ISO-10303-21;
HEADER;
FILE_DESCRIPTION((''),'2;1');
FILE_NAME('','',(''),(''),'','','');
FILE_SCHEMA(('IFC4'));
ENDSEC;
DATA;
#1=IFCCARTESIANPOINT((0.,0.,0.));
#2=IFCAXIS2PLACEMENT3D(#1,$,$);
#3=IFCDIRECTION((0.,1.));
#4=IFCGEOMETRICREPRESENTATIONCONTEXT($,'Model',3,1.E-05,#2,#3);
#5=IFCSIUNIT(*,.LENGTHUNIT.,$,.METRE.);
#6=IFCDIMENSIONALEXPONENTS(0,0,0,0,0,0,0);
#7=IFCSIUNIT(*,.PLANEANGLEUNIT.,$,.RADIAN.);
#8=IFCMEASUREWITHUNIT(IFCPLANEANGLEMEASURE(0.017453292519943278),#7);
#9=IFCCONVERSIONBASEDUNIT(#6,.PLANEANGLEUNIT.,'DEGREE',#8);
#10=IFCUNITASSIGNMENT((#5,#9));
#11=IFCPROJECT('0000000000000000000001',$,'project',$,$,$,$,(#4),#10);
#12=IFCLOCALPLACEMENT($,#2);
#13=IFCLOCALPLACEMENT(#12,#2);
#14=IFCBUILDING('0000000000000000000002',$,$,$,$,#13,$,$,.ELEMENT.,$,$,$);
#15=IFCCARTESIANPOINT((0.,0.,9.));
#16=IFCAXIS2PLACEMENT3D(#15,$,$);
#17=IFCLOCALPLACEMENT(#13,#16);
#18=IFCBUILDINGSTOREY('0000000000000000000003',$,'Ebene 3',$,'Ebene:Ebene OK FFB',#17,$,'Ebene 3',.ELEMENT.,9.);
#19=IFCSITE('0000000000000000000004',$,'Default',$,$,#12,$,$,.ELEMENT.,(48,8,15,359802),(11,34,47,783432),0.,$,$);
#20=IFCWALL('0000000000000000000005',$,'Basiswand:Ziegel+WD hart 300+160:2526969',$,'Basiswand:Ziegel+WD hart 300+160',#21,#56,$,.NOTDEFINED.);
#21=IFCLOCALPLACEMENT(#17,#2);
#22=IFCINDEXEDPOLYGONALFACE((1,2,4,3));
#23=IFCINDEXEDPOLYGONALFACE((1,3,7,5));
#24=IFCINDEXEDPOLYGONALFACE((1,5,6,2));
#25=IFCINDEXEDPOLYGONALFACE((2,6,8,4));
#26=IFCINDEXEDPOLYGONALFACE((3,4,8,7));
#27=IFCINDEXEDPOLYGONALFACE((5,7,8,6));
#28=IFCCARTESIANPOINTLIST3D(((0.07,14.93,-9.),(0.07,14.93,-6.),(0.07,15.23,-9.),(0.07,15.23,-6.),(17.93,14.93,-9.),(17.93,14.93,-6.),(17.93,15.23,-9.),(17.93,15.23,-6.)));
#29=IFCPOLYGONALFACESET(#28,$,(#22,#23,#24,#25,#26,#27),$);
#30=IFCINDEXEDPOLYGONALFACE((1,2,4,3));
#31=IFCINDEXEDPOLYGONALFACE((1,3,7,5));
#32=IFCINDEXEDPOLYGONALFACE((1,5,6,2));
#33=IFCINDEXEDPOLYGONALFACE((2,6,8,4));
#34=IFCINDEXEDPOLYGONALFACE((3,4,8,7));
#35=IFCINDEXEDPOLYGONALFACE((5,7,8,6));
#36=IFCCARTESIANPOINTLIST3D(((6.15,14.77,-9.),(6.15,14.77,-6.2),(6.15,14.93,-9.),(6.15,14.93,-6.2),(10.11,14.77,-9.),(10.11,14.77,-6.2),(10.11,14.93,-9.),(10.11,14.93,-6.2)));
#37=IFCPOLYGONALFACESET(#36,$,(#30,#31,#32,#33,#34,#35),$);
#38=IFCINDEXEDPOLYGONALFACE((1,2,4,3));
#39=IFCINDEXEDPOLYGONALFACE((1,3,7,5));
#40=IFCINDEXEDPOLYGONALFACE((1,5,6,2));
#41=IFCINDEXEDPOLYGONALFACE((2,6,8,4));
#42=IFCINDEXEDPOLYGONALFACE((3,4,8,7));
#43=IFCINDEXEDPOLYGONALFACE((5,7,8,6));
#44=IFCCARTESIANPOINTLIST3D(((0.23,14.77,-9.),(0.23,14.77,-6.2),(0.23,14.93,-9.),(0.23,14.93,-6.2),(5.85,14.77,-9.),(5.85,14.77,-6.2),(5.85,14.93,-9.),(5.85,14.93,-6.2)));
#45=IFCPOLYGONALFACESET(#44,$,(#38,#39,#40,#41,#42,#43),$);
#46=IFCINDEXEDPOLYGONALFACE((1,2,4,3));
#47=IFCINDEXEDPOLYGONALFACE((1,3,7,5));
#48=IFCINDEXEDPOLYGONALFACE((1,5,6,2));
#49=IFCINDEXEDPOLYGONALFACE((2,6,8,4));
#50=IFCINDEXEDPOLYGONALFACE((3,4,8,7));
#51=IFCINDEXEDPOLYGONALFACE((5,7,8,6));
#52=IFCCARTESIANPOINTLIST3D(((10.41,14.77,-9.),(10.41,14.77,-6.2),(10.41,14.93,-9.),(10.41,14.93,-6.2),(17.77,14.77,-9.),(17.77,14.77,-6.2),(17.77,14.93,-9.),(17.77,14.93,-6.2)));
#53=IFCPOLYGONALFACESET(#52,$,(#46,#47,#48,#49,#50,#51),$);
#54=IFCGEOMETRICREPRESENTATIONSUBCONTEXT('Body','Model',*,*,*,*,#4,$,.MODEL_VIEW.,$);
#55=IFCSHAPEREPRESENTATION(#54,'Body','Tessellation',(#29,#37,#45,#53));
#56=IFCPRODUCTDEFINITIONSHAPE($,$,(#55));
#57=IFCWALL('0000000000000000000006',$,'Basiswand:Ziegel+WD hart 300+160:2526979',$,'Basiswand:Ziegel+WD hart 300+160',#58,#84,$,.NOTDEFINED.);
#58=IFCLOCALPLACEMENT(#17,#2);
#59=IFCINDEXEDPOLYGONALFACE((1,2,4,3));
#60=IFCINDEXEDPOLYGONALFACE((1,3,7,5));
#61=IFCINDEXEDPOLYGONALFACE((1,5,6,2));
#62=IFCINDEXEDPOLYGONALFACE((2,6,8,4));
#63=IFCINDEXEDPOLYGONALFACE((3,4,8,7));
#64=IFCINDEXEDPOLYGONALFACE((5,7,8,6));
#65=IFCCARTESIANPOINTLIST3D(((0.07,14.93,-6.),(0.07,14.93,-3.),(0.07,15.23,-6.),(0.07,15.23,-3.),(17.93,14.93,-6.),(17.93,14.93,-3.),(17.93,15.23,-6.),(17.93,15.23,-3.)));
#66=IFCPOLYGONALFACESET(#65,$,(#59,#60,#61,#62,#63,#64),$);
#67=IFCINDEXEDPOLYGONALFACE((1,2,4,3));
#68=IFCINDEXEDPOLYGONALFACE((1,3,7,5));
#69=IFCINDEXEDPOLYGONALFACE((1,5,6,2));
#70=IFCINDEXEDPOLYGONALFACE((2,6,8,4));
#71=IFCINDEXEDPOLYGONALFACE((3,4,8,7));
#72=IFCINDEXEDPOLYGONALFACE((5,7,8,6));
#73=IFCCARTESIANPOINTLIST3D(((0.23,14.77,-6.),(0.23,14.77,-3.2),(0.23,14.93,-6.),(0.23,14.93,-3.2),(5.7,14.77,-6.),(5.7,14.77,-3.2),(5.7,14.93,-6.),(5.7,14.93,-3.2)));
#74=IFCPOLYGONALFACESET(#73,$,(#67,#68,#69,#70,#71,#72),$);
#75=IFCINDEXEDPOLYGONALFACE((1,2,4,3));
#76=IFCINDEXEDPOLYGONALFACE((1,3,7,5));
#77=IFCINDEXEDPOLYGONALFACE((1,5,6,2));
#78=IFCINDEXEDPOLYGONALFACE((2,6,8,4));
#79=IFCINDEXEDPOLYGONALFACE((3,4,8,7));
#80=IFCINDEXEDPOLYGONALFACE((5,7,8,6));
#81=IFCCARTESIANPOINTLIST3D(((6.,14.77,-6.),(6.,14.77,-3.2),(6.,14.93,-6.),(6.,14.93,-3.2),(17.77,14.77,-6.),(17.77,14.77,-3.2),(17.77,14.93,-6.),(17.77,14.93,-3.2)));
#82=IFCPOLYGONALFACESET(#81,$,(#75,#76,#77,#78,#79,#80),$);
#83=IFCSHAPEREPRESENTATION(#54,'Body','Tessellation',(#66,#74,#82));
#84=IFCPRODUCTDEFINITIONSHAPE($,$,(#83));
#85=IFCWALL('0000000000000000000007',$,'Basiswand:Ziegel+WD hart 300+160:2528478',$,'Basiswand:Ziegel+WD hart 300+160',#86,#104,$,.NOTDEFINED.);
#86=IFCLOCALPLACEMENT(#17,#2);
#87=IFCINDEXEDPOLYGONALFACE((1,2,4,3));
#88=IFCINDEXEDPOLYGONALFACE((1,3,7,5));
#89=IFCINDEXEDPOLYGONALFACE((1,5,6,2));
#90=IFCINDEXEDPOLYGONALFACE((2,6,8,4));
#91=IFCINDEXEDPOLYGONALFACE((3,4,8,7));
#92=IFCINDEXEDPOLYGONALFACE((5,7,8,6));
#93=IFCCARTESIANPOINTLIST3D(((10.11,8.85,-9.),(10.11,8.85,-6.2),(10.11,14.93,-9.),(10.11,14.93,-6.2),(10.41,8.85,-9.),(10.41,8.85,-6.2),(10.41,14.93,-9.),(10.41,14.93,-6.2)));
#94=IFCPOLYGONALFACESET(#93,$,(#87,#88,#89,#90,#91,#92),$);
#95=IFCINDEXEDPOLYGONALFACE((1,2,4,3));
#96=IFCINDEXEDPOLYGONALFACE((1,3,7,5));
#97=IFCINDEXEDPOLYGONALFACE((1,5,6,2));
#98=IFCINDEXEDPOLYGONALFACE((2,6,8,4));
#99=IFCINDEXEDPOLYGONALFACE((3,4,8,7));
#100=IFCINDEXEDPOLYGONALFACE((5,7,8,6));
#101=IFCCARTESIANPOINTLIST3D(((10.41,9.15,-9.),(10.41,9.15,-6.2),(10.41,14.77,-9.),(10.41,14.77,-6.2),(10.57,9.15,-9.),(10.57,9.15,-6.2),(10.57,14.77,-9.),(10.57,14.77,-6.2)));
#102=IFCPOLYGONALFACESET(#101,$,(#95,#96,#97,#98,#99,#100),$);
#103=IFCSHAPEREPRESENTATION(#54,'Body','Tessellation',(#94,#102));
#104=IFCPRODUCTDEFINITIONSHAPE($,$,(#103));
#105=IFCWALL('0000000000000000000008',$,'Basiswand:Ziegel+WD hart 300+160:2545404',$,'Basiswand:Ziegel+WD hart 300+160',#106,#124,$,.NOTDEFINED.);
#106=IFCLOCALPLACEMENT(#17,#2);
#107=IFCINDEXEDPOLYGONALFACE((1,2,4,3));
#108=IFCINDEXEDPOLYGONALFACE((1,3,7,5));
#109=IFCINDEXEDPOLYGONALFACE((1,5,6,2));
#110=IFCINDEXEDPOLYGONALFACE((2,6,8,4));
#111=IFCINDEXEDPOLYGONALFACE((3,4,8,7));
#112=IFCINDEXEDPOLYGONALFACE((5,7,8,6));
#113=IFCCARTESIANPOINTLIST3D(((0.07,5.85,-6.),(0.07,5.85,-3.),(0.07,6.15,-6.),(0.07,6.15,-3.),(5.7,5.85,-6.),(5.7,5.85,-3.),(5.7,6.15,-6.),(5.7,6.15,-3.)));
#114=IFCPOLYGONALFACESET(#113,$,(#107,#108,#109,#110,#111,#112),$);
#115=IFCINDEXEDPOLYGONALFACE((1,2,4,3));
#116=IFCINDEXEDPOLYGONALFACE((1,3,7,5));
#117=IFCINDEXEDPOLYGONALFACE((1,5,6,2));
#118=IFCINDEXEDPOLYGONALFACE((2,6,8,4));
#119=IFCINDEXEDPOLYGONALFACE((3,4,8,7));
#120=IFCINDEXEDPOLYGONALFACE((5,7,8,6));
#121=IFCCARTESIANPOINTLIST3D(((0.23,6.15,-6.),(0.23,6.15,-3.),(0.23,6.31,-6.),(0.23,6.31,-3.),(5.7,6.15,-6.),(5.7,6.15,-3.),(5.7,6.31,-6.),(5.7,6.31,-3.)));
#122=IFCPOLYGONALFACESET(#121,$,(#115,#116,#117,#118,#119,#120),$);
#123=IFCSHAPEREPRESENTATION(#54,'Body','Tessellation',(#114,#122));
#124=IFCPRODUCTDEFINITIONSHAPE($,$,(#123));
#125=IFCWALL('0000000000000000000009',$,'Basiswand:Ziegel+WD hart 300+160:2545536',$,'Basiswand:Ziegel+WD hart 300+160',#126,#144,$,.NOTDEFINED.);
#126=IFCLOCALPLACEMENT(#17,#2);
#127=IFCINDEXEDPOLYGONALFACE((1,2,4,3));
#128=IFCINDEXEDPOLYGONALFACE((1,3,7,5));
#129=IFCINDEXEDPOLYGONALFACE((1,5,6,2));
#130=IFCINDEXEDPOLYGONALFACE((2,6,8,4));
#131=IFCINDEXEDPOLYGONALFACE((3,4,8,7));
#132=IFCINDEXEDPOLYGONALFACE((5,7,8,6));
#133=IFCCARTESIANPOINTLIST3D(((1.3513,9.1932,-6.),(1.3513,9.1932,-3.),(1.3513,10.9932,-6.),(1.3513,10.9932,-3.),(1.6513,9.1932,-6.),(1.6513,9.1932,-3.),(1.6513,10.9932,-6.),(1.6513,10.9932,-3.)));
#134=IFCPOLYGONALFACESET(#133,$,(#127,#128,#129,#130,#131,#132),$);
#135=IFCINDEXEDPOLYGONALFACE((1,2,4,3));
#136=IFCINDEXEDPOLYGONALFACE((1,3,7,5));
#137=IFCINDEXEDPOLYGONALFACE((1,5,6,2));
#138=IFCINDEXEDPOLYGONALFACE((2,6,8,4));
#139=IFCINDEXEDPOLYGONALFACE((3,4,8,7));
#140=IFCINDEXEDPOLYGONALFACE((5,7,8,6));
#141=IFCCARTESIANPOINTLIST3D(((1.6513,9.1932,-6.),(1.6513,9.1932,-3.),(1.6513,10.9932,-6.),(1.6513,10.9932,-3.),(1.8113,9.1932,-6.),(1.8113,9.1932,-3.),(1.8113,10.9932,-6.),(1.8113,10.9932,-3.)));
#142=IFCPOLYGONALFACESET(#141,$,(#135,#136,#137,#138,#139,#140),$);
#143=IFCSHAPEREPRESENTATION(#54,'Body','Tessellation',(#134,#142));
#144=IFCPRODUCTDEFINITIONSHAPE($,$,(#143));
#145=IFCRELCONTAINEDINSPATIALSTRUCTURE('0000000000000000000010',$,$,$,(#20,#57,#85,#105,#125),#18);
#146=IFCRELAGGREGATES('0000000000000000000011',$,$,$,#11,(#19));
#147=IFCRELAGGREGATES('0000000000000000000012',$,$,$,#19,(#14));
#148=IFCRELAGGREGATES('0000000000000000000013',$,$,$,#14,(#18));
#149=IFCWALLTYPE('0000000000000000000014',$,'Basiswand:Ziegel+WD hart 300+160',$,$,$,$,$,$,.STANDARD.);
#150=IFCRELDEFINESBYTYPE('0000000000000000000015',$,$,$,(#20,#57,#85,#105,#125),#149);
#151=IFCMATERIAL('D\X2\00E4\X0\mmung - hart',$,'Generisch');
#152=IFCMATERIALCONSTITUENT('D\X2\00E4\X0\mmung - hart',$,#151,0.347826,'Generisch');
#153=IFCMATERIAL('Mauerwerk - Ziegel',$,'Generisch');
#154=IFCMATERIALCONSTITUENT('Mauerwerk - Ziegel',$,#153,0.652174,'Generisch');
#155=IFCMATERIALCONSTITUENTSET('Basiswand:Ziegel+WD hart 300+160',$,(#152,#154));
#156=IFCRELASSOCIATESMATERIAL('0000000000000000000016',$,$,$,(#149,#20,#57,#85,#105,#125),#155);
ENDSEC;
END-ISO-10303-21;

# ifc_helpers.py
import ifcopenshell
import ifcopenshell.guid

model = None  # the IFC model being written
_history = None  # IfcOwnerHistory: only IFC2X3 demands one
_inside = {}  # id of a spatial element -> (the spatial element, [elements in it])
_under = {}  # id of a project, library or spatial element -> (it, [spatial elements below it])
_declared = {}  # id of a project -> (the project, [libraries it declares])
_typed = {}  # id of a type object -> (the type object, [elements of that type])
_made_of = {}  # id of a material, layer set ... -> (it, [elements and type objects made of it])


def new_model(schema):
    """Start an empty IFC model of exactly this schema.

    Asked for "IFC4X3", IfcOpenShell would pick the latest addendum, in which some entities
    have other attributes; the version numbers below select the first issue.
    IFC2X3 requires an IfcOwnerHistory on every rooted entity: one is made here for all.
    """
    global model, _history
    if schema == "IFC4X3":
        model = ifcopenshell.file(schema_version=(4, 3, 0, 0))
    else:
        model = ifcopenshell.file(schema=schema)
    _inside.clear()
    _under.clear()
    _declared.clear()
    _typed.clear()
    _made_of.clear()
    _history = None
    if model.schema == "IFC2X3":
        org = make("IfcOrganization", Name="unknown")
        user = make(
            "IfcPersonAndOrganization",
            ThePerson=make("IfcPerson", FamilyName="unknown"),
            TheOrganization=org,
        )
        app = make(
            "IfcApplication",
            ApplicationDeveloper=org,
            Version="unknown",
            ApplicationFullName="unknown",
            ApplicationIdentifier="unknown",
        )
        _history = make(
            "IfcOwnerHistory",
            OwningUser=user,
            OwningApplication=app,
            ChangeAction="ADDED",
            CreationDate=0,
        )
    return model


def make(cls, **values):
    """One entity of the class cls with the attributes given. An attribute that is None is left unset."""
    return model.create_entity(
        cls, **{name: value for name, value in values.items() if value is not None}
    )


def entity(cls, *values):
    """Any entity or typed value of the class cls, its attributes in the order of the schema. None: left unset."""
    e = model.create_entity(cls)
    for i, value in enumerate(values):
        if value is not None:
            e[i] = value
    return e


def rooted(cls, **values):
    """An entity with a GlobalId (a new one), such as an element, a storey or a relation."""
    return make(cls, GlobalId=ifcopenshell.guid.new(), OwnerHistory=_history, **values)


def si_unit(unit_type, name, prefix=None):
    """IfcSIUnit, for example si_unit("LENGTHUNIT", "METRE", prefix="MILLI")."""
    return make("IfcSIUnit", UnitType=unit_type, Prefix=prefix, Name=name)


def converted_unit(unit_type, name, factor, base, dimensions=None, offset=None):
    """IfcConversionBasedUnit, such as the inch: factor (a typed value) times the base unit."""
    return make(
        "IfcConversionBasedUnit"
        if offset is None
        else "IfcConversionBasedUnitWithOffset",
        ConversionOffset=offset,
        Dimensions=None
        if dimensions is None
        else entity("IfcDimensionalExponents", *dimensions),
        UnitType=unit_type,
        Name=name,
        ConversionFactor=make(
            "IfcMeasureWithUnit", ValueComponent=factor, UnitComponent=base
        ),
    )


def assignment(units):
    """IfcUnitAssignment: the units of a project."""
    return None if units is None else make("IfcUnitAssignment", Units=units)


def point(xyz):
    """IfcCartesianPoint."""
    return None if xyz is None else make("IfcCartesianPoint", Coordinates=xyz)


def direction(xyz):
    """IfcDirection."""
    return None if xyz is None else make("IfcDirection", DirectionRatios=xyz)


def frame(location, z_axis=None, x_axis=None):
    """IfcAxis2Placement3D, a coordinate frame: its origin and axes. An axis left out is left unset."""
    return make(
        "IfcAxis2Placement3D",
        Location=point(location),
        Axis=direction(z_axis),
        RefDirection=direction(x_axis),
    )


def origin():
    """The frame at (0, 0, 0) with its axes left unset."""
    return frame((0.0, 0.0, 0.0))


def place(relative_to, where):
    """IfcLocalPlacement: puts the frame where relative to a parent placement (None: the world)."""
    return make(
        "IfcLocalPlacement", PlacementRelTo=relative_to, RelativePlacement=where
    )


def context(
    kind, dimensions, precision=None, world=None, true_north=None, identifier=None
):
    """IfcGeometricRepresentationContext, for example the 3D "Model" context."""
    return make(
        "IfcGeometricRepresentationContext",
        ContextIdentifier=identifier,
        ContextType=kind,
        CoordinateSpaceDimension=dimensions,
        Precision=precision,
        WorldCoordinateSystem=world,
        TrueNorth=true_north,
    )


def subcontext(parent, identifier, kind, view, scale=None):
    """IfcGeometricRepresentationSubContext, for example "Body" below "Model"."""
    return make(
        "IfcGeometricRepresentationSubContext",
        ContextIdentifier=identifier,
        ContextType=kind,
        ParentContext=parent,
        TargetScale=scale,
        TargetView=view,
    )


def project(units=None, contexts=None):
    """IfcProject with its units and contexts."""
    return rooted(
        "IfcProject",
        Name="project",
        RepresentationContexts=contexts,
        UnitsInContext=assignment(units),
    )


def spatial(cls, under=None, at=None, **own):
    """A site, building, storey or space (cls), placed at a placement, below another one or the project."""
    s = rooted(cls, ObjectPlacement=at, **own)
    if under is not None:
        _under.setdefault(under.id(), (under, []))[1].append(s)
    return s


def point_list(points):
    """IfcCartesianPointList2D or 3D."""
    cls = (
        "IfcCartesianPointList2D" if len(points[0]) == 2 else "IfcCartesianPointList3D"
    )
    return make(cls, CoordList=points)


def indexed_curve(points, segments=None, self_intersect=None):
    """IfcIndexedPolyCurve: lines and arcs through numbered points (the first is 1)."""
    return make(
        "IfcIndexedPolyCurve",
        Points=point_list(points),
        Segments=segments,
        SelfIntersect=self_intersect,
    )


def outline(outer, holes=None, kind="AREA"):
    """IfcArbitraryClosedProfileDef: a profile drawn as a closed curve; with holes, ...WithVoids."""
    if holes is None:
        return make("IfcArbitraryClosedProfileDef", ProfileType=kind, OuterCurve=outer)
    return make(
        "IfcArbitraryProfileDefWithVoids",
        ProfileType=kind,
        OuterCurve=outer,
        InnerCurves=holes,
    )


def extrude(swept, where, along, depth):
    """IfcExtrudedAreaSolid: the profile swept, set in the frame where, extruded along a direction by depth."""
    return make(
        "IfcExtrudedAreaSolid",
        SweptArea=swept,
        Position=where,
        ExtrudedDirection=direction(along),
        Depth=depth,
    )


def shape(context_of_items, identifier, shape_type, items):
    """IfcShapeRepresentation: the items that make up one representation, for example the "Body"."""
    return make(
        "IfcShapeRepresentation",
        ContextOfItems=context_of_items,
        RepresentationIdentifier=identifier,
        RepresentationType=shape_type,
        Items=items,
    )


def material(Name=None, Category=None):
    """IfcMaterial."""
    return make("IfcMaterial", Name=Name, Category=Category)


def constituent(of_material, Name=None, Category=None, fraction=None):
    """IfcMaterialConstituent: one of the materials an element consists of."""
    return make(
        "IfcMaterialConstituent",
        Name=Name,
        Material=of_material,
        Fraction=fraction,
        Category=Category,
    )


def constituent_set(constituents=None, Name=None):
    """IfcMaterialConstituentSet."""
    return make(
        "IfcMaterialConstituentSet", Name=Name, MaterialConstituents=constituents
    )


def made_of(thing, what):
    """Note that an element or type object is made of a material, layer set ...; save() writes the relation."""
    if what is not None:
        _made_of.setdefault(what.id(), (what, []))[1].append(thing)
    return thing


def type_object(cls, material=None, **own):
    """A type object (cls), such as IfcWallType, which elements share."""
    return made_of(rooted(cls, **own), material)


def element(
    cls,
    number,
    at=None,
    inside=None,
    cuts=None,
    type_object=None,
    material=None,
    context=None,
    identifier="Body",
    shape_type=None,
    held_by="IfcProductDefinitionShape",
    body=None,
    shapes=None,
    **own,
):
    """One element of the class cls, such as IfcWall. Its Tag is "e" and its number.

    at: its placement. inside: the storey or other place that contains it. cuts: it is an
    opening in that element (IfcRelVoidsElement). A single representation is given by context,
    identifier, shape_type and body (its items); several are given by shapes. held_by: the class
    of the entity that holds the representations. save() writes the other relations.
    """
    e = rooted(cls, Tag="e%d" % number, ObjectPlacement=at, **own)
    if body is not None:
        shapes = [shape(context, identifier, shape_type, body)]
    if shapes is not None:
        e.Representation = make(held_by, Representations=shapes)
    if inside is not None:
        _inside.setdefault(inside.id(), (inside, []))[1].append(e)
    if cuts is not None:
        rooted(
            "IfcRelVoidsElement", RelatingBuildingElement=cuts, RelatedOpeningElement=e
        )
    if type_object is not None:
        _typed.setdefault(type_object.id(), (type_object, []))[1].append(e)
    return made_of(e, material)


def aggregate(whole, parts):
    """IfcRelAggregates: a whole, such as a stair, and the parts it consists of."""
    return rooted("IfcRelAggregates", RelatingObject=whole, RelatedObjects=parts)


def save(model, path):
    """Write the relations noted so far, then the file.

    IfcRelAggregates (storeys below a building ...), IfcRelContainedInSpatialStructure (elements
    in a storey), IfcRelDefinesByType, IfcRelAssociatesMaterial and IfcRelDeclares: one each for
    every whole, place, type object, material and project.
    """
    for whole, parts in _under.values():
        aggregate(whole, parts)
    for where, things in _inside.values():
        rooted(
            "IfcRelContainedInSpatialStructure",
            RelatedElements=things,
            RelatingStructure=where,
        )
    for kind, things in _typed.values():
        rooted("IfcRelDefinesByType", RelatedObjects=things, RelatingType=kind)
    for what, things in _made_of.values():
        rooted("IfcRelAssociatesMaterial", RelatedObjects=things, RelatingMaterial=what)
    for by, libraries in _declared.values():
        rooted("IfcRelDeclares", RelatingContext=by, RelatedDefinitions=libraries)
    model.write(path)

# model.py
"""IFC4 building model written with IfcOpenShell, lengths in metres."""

from ifc_helpers import new_model, entity, si_unit, converted_unit, direction, frame, origin, place, context, subcontext, project, spatial, indexed_curve, outline, extrude, material, constituent, constituent_set, type_object, element, save


model = new_model("IFC4")

# Units and contexts
model_context = context("Model", 3, precision=1e-05, world=origin(), true_north=direction((0.0, 1.0)))
body_context = subcontext(model_context, "Body", "Model", "MODEL_VIEW")
ifc_project = project(units=[si_unit("LENGTHUNIT", "METRE"), converted_unit("PLANEANGLEUNIT", "DEGREE", entity("IfcPlaneAngleMeasure", 0.017453292519943278), si_unit("PLANEANGLEUNIT", "RADIAN"), dimensions=[0, 0, 0, 0, 0, 0, 0])], contexts=[model_context])

# Site, building, storey
site_placement = place(None, origin())
site = spatial("IfcSite", under=ifc_project, at=site_placement, Name="Default", CompositionType="ELEMENT", RefLatitude=(48, 8, 15, 359802), RefLongitude=(11, 34, 47, 783432), RefElevation=0.0)
building_placement = place(site_placement, origin())
building = spatial("IfcBuilding", under=site, at=building_placement, CompositionType="ELEMENT")
storey_placement = place(building_placement, frame((0.0, 0.0, 9.0)))
storey = spatial("IfcBuildingStorey", under=building, at=storey_placement, Name="Ebene 3", ObjectType="Ebene:Ebene OK FFB", LongName="Ebene 3", CompositionType="ELEMENT", Elevation=9.0)

# Walls
ifc_material_1 = material(Name="Dämmung - hart", Category="Generisch")
ifc_constituent_1 = constituent(ifc_material_1, Name="Dämmung - hart", Category="Generisch", fraction=0.347826)
ifc_material_2 = material(Name="Mauerwerk - Ziegel", Category="Generisch")
ifc_constituent_2 = constituent(ifc_material_2, Name="Mauerwerk - Ziegel", Category="Generisch", fraction=0.652174)
ifc_constituent_set_1 = constituent_set(constituents=[ifc_constituent_1, ifc_constituent_2], Name="Basiswand:Ziegel+WD hart 300+160")
wall_type = type_object("IfcWallType", Name="Basiswand:Ziegel+WD hart 300+160", PredefinedType="STANDARD", material=ifc_constituent_set_1)
wall_1_placement = place(storey_placement, frame((17.77, 15.0, -9.0), z_axis=(0.0, 0.0, 1.0), x_axis=(-1.0, 0.0, 0.0)))
element("IfcWall", 1, at=wall_1_placement, inside=storey, type_object=wall_type, material=ifc_constituent_set_1, Name="Basiswand:Ziegel+WD hart 300+160:2526969", ObjectType="Basiswand:Ziegel+WD hart 300+160", PredefinedType="NOTDEFINED", context=body_context, shape_type="SweptSolid", body=[
    extrude(outline(indexed_curve([(-0.15, -8.93), (0.15, -8.93), (0.15, 8.93), (-0.15, 8.93), (-0.15, -8.93)], self_intersect=False)), frame((8.77, -0.08, 0.0), z_axis=(0.0, 0.0, 1.0), x_axis=(0.0, 1.0, 0.0)), (0.0, 0.0, 1.0), 3.0),
    extrude(outline(indexed_curve([(-1.98, -0.08), (1.98, -0.08), (1.98, 0.08), (-1.98, 0.08), (-1.98, -0.08)], self_intersect=False)), frame((9.64, 0.15, 0.0)), (0.0, 0.0, 1.0), 2.8),
    extrude(outline(indexed_curve([(-2.81, -0.08), (2.81, -0.08), (2.81, 0.08), (-2.81, 0.08), (-2.81, -0.08)], self_intersect=False)), frame((14.73, 0.15, 0.0), z_axis=(0.0, 0.0, 1.0), x_axis=(-1.0, 0.0, 0.0)), (0.0, 0.0, 1.0), 2.8),
    extrude(outline(indexed_curve([(-3.68, -0.08), (3.68, -0.08), (3.68, 0.08), (-3.68, 0.08), (-3.68, -0.08)], self_intersect=False)), frame((3.68, 0.15, 0.0)), (0.0, 0.0, 1.0), 2.8),
])
wall_2_placement = place(storey_placement, frame((17.77, 15.0, -6.0), z_axis=(0.0, 0.0, 1.0), x_axis=(-1.0, 0.0, 0.0)))
element("IfcWall", 2, at=wall_2_placement, inside=storey, type_object=wall_type, material=ifc_constituent_set_1, Name="Basiswand:Ziegel+WD hart 300+160:2526979", ObjectType="Basiswand:Ziegel+WD hart 300+160", PredefinedType="NOTDEFINED", context=body_context, shape_type="SweptSolid", body=[
    extrude(outline(indexed_curve([(-0.15, -8.93), (0.15, -8.93), (0.15, 8.93), (-0.15, 8.93), (-0.15, -8.93)], self_intersect=False)), frame((8.77, -0.08, 0.0), z_axis=(0.0, 0.0, 1.0), x_axis=(0.0, 1.0, 0.0)), (0.0, 0.0, 1.0), 3.0),
    extrude(outline(indexed_curve([(-2.735, -0.08), (2.735, -0.08), (2.735, 0.08), (-2.735, 0.08), (-2.735, -0.08)], self_intersect=False)), frame((14.805, 0.15, 0.0), z_axis=(0.0, 0.0, 1.0), x_axis=(-1.0, 0.0, 0.0)), (0.0, 0.0, 1.0), 2.8),
    extrude(outline(indexed_curve([(-5.885, -0.08), (5.885, -0.08), (5.885, 0.08), (-5.885, 0.08), (-5.885, -0.08)], self_intersect=False)), frame((5.885, 0.15, 0.0)), (0.0, 0.0, 1.0), 2.8),
])

# Wall
wall_3_placement = place(storey_placement, frame((10.34, 14.77, -9.0), z_axis=(0.0, 0.0, 1.0), x_axis=(0.0, -1.0, 0.0)))
element("IfcWall", 3, at=wall_3_placement, inside=storey, type_object=wall_type, material=ifc_constituent_set_1, Name="Basiswand:Ziegel+WD hart 300+160:2528478", ObjectType="Basiswand:Ziegel+WD hart 300+160", PredefinedType="NOTDEFINED", context=body_context, shape_type="SweptSolid", body=[
    extrude(outline(indexed_curve([(-1.4, -3.04), (1.4, -3.04), (1.4, 3.04), (-1.4, 3.04), (-1.4, -3.04)], self_intersect=False)), frame((2.88, -0.23, 1.4), z_axis=(0.0, 1.0, 0.0), x_axis=(0.0, 0.0, 1.0)), (0.0, 0.0, 1.0), 0.3),
    extrude(outline(indexed_curve([(-1.4, -2.81), (1.4, -2.81), (1.4, 2.81), (-1.4, 2.81), (-1.4, -2.81)], self_intersect=False)), frame((2.81, 0.07, 1.4), z_axis=(0.0, 1.0, 0.0), x_axis=(0.0, 0.0, 1.0)), (0.0, 0.0, 1.0), 0.16),
])

# Walls
wall_4_placement = place(storey_placement, frame((0.23, 6.08, -6.0)))
element("IfcWall", 4, at=wall_4_placement, inside=storey, type_object=wall_type, material=ifc_constituent_set_1, Name="Basiswand:Ziegel+WD hart 300+160:2545404", ObjectType="Basiswand:Ziegel+WD hart 300+160", PredefinedType="NOTDEFINED", context=body_context, shape_type="SweptSolid", body=[
    extrude(outline(indexed_curve([(-0.15, -2.815), (0.15, -2.815), (0.15, 2.815), (-0.15, 2.815), (-0.15, -2.815)], self_intersect=False)), frame((2.655, -0.08, 0.0), z_axis=(0.0, 0.0, 1.0), x_axis=(0.0, 1.0, 0.0)), (0.0, 0.0, 1.0), 3.0),
    extrude(outline(indexed_curve([(-0.08, -2.735), (0.08, -2.735), (0.08, 2.735), (-0.08, 2.735), (-0.08, -2.735)], self_intersect=False)), frame((2.735, 0.15, 0.0), z_axis=(0.0, 0.0, 1.0), x_axis=(0.0, 1.0, 0.0)), (0.0, 0.0, 1.0), 3.0),
])
wall_5_placement = place(storey_placement, frame((1.5813, 10.9932, -6.0), z_axis=(0.0, 0.0, 1.0), x_axis=(0.0, -1.0, 0.0)))
element("IfcWall", 5, at=wall_5_placement, inside=storey, type_object=wall_type, material=ifc_constituent_set_1, Name="Basiswand:Ziegel+WD hart 300+160:2545536", ObjectType="Basiswand:Ziegel+WD hart 300+160", PredefinedType="NOTDEFINED", context=body_context, shape_type="SweptSolid", body=[
    extrude(outline(indexed_curve([(-0.15, -0.9), (0.15, -0.9), (0.15, 0.9), (-0.15, 0.9), (-0.15, -0.9)], self_intersect=False)), frame((0.9, -0.08, 0.0), z_axis=(0.0, 0.0, 1.0), x_axis=(0.0, 1.0, 0.0)), (0.0, 0.0, 1.0), 3.0),
    extrude(outline(indexed_curve([(-0.08, -0.9), (0.08, -0.9), (0.08, 0.9), (-0.08, 0.9), (-0.08, -0.9)], self_intersect=False)), frame((0.9, 0.15, 0.0), z_axis=(0.0, 0.0, 1.0), x_axis=(0.0, -1.0, 0.0)), (0.0, 0.0, 1.0), 3.0),
])

save(model, "model.ifc")
